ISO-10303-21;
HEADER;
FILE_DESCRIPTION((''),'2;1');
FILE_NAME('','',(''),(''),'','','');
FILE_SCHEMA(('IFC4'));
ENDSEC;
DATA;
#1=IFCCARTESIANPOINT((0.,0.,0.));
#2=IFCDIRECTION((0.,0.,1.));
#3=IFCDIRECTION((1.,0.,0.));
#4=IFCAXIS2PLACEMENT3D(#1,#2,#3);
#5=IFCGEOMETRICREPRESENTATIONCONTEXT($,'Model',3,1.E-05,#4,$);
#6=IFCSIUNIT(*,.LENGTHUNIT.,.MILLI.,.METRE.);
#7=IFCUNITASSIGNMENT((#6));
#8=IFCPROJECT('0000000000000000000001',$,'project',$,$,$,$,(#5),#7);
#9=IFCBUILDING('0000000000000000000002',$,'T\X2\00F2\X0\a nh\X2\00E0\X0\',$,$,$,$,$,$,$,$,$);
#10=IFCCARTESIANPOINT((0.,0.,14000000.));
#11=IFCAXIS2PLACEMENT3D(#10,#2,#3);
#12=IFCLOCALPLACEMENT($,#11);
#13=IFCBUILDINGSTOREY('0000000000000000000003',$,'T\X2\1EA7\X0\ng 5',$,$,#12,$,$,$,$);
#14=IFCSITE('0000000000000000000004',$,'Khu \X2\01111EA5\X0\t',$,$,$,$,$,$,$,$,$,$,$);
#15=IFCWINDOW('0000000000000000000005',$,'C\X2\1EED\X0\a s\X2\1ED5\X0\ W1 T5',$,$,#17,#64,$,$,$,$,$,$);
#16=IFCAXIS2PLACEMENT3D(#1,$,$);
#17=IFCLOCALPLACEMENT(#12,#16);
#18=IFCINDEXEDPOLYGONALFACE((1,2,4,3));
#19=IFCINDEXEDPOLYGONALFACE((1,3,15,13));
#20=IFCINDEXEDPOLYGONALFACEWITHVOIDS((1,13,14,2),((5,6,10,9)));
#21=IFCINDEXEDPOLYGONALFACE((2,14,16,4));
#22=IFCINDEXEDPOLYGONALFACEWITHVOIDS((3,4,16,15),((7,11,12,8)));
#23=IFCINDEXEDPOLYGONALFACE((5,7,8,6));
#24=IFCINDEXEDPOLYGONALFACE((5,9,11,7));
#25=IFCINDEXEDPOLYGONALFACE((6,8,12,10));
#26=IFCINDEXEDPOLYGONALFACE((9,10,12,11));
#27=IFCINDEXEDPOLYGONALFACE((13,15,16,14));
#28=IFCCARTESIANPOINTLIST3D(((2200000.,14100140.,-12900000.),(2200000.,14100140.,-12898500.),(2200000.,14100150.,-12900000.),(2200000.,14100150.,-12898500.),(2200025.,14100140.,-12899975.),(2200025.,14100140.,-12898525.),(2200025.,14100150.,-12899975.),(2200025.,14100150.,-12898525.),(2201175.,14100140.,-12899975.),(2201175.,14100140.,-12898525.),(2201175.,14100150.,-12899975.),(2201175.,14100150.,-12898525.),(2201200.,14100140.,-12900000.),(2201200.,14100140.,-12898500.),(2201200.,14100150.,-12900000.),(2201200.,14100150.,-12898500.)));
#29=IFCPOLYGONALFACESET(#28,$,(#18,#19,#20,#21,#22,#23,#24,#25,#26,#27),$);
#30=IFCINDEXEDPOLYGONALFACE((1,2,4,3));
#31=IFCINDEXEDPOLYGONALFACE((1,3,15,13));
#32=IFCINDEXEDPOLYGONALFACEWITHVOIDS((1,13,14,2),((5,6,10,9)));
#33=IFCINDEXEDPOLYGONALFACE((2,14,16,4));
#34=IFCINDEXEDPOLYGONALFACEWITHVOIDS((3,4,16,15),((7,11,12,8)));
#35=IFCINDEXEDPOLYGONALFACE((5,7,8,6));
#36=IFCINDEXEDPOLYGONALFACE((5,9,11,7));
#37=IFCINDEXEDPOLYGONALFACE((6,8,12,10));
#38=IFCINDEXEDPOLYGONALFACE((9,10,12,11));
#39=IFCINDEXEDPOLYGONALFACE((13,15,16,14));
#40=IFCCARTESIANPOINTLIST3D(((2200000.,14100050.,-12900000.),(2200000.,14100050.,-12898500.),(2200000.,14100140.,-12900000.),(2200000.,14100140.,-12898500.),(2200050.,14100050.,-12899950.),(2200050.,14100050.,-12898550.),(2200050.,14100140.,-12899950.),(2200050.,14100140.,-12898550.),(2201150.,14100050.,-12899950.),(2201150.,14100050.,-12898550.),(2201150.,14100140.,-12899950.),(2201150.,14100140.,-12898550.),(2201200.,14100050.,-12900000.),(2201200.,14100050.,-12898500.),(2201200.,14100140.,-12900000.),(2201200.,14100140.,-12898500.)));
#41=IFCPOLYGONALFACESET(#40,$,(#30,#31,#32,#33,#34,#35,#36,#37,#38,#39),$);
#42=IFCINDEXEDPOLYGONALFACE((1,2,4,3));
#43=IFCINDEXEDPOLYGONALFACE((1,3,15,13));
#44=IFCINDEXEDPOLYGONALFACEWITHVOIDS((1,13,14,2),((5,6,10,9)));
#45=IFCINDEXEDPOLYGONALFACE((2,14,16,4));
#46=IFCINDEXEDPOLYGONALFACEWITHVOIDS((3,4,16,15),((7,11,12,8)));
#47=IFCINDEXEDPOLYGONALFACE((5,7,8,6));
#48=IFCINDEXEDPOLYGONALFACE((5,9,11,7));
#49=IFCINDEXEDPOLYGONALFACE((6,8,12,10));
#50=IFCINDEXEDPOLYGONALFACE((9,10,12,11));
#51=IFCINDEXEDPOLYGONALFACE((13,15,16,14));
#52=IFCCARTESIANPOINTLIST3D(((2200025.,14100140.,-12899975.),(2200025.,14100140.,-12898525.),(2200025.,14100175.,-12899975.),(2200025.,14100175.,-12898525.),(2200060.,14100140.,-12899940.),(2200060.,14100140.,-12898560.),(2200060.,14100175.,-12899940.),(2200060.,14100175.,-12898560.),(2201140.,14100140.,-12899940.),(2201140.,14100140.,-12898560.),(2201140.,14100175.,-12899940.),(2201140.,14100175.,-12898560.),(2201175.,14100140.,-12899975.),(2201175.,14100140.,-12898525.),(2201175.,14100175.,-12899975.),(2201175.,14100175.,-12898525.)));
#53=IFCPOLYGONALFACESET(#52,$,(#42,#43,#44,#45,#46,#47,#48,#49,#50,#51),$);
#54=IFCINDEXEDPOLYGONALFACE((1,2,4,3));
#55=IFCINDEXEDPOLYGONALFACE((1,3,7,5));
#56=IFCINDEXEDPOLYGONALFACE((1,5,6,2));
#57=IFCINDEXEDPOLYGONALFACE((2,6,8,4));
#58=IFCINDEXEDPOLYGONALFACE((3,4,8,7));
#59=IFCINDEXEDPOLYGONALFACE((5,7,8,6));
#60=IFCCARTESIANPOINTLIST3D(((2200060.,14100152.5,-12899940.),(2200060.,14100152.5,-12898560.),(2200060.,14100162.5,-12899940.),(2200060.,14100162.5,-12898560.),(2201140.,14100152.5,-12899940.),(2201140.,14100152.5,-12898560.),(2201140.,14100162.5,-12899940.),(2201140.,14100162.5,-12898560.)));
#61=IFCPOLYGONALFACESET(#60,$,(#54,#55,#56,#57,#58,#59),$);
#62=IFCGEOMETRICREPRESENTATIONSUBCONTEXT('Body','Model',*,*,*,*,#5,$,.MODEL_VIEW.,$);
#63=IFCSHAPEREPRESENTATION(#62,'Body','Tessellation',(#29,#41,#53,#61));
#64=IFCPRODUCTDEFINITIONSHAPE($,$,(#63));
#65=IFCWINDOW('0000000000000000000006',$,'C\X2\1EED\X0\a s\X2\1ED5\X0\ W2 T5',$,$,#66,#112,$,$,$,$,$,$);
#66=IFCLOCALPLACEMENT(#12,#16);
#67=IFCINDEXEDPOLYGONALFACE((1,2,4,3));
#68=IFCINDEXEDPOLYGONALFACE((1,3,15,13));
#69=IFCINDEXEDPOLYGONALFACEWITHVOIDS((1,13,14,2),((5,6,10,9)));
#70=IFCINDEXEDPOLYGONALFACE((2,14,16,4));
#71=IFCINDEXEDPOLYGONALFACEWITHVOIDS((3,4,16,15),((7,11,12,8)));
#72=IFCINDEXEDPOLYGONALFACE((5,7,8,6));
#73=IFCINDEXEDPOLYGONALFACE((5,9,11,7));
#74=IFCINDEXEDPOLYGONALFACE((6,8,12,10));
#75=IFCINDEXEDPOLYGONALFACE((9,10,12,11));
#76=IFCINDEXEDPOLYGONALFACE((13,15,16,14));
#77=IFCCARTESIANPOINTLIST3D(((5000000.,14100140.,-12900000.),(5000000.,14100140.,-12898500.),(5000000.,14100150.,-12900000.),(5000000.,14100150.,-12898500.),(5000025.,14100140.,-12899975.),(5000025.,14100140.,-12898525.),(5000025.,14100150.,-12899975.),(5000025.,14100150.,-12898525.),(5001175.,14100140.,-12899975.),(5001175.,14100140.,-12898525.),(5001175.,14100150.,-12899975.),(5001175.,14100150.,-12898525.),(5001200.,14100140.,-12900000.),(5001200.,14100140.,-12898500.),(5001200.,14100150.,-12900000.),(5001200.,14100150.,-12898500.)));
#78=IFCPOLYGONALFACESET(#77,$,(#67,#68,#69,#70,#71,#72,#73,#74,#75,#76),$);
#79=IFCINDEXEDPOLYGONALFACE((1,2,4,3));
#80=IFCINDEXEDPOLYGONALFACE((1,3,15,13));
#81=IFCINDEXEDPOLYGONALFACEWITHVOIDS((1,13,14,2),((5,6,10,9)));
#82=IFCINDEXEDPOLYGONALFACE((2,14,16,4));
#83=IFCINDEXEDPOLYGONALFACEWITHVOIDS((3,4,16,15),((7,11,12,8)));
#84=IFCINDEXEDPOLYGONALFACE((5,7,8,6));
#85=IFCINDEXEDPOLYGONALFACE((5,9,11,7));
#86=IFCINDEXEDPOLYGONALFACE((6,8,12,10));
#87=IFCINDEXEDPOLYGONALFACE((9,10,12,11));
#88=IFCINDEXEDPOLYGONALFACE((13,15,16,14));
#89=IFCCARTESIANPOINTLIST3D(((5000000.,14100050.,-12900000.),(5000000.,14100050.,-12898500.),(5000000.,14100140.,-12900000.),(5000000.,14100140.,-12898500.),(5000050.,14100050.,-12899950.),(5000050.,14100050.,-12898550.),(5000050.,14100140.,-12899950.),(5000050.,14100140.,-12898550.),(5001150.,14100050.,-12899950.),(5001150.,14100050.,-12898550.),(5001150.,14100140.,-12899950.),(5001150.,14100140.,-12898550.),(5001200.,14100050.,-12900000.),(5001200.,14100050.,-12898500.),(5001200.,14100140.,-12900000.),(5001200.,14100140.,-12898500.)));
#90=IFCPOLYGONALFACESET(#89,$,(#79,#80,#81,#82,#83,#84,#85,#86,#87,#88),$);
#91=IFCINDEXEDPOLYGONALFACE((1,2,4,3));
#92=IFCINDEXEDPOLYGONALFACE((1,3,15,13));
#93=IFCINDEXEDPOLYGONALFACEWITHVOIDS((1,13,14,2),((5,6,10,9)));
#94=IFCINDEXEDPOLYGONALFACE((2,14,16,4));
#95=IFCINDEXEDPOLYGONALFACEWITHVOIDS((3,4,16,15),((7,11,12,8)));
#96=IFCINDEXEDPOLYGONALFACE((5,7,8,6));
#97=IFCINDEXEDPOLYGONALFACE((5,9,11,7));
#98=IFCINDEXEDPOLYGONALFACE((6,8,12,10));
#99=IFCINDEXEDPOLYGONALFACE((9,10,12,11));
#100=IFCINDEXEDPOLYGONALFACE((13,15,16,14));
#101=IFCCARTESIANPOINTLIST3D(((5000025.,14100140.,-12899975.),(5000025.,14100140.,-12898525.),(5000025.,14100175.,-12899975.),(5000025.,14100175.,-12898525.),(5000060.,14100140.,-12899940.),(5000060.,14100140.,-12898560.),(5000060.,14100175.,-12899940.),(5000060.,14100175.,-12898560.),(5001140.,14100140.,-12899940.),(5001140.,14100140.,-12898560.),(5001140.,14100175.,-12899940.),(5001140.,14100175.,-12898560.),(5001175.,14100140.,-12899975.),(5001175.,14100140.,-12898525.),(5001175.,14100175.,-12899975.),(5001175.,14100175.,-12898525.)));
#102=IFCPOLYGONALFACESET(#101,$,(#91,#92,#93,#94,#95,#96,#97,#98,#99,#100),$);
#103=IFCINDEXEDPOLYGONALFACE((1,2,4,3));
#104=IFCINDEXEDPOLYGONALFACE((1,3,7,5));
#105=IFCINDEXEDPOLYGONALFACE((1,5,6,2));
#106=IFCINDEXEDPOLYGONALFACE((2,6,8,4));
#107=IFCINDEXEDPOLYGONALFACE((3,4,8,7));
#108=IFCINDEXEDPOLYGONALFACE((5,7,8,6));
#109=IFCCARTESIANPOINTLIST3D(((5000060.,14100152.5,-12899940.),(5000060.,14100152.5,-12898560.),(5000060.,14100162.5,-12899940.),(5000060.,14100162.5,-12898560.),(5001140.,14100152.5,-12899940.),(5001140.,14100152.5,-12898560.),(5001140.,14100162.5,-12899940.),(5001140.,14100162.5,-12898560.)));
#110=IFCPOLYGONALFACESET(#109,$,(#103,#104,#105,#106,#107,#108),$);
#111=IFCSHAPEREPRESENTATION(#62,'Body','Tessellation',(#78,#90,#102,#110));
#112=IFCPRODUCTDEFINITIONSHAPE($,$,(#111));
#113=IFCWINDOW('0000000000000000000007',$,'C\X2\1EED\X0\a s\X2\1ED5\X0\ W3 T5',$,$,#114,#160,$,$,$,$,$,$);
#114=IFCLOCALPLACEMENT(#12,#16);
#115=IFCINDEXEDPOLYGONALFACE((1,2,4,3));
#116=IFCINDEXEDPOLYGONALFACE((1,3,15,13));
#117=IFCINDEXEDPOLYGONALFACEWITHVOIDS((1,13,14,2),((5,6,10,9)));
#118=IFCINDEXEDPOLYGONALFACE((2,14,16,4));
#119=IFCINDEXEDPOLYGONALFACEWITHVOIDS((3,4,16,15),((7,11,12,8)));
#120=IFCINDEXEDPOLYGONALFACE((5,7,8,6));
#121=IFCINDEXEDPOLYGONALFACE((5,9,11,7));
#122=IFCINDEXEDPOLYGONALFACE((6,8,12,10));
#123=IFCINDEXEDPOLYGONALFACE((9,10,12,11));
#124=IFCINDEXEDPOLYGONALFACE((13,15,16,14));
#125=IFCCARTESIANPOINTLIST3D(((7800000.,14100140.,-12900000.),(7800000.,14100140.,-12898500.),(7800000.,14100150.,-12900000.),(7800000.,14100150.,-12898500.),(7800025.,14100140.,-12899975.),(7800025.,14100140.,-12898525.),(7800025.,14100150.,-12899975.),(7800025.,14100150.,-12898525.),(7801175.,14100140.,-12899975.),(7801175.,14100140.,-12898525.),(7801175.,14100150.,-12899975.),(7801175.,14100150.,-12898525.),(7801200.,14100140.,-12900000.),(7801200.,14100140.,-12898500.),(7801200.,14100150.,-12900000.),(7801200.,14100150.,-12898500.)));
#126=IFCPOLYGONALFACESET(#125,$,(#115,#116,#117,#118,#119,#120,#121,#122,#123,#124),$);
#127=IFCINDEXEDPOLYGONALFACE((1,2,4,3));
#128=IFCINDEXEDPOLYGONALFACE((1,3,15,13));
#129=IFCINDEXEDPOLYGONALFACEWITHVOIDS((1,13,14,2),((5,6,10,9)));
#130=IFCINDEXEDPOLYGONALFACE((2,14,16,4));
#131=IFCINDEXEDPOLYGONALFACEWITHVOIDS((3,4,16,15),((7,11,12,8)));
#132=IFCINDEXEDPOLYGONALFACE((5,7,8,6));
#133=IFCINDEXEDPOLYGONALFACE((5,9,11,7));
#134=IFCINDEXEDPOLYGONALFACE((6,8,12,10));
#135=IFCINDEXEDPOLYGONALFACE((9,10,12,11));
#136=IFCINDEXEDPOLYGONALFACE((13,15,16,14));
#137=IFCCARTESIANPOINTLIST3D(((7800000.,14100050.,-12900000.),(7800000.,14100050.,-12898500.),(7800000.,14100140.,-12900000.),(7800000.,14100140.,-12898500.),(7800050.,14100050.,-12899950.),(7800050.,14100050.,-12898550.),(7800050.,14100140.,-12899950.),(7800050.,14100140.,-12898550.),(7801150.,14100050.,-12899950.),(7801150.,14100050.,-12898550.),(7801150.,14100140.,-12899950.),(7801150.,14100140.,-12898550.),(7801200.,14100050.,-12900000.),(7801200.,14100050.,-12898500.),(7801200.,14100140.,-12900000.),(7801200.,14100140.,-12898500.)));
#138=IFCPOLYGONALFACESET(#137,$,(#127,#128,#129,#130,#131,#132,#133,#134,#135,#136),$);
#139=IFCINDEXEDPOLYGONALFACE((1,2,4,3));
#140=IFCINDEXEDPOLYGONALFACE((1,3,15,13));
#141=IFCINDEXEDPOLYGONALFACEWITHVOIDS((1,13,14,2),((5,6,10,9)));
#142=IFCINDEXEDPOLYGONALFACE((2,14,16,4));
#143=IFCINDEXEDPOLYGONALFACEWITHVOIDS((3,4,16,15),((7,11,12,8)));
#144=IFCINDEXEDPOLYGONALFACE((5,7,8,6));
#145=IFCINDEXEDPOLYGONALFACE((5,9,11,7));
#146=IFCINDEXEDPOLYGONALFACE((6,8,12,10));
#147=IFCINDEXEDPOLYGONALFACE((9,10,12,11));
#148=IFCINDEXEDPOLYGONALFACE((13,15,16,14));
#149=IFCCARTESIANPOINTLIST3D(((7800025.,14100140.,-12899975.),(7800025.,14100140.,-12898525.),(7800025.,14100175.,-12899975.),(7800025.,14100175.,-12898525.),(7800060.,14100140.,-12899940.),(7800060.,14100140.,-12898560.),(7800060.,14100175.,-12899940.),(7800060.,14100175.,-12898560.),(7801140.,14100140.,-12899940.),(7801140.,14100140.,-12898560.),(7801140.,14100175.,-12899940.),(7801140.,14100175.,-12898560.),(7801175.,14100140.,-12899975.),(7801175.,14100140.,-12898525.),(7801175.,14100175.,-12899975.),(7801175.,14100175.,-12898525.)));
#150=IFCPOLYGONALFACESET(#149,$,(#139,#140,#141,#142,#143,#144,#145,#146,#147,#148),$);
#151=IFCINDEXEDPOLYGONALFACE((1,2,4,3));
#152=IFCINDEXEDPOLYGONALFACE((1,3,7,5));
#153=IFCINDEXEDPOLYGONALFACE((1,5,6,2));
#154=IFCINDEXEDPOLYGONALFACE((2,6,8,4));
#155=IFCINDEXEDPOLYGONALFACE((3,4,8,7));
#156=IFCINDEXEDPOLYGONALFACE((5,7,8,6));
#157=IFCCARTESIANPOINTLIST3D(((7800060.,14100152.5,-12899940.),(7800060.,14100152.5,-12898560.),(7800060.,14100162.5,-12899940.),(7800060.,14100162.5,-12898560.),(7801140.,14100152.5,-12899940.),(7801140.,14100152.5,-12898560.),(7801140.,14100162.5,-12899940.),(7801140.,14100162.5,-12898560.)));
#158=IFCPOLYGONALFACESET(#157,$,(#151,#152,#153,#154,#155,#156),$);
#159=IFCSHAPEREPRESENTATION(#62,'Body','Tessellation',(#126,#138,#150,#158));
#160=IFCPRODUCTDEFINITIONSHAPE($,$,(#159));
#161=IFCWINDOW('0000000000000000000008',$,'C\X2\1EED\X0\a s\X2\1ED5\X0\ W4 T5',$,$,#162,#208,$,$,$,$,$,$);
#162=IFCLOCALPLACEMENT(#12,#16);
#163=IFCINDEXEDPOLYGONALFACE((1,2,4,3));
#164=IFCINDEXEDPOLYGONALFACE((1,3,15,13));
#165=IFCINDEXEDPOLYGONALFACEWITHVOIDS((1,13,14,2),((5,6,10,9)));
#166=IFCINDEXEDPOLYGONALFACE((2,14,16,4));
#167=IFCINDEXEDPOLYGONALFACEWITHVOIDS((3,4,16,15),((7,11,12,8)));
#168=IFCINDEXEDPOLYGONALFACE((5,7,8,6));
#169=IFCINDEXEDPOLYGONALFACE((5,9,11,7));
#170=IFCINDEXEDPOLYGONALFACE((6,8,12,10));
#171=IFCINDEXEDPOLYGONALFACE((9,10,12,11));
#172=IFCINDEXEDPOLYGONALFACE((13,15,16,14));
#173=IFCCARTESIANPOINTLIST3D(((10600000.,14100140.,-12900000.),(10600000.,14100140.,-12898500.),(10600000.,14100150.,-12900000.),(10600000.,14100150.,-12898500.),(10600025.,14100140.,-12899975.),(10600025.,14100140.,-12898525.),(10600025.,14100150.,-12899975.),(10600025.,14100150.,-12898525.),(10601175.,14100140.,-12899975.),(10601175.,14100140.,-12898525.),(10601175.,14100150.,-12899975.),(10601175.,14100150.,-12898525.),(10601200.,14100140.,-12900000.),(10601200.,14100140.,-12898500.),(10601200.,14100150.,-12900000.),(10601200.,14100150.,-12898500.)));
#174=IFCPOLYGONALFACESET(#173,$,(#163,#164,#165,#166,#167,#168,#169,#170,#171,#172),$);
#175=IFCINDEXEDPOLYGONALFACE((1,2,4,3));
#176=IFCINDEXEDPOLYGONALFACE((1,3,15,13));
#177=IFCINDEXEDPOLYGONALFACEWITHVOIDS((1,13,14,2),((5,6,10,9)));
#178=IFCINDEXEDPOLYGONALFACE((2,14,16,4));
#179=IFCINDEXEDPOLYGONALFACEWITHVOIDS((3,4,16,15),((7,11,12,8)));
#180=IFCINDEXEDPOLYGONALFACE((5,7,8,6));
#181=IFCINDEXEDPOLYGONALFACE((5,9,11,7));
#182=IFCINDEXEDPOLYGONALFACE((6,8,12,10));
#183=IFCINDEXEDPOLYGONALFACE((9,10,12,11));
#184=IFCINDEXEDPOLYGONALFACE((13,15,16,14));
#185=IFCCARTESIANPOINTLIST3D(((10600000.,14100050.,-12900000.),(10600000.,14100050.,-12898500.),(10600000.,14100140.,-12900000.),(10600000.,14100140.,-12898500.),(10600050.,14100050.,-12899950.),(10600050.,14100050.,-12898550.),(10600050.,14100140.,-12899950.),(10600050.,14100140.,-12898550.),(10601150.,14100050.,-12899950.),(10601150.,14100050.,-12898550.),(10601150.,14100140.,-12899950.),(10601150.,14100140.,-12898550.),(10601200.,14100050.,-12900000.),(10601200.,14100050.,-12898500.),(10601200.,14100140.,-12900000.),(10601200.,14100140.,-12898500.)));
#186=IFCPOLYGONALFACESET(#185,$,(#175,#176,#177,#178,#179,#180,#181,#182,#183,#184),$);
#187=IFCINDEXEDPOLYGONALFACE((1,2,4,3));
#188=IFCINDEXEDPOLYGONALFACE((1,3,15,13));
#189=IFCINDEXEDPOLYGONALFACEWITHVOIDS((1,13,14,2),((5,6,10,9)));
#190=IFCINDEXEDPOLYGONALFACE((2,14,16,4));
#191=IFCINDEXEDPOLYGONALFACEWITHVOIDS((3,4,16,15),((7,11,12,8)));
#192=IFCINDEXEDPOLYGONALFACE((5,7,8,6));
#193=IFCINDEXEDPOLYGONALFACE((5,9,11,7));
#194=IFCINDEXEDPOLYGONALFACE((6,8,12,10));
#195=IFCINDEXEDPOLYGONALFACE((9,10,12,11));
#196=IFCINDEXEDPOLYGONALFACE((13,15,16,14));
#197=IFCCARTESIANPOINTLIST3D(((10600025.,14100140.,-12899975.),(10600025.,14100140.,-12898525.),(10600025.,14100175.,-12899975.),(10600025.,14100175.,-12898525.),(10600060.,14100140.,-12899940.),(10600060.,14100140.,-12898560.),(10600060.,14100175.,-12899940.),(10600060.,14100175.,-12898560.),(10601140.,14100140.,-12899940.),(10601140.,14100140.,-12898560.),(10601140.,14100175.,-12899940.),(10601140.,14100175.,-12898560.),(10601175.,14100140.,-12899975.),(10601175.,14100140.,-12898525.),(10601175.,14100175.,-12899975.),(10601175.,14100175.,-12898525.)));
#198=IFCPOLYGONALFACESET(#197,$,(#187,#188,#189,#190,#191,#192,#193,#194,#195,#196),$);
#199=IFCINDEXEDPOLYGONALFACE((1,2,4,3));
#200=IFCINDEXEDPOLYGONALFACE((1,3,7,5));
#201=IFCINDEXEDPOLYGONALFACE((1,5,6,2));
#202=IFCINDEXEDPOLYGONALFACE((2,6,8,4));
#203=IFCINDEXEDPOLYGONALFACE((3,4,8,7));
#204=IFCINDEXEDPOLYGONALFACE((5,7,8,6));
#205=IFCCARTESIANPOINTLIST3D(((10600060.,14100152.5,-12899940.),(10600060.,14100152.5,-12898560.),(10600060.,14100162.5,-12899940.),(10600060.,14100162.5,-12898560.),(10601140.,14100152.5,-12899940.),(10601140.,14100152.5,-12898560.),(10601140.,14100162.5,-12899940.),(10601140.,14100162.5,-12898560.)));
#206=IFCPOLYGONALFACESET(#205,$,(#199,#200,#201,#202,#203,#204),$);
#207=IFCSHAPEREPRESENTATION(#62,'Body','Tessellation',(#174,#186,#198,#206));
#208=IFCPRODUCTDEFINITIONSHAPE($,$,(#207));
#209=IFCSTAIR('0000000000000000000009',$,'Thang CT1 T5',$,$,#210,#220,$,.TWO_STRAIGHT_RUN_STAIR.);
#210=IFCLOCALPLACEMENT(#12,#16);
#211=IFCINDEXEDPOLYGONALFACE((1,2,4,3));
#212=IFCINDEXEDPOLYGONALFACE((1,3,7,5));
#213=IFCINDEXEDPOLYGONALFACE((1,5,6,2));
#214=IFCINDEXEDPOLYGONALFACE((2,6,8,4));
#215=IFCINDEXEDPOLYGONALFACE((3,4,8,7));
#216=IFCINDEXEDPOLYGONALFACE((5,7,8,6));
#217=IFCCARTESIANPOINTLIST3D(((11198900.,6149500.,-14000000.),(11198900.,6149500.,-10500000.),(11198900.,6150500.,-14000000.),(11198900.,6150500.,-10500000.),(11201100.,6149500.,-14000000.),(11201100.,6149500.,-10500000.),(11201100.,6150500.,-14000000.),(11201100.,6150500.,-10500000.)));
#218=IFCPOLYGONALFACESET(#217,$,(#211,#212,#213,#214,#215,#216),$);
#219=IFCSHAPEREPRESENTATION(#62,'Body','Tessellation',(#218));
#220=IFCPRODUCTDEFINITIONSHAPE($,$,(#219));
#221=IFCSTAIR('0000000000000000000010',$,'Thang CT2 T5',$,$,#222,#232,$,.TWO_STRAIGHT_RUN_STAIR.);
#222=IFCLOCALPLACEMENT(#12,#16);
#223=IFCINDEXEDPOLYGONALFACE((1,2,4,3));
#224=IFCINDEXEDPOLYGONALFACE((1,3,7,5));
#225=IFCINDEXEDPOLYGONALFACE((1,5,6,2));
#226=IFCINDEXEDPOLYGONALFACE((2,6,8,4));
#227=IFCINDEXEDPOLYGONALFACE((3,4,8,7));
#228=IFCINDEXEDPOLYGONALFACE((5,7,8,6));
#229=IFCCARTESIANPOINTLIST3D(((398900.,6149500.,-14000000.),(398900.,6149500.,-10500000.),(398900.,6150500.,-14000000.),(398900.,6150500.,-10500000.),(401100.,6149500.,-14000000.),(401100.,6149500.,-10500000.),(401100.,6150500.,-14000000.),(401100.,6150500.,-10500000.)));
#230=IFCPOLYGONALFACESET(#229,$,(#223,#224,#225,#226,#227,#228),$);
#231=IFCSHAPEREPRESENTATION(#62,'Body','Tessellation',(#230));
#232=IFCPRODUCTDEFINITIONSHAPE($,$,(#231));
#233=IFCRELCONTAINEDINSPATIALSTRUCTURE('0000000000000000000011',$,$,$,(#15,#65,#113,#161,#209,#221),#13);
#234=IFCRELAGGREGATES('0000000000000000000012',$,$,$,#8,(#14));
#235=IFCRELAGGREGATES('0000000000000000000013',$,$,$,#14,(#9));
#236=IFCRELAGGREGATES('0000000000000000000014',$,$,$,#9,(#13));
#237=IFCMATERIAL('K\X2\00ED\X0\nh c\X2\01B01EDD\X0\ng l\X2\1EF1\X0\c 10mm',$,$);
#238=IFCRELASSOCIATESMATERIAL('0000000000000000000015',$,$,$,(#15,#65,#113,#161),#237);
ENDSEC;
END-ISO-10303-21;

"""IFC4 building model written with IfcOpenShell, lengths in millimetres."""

from ifc_helpers import new_model, entity, si_unit, frame, origin_with_axes, place, context, subcontext, project, spatial, line, indexed_curve, outline, extrude, material, element, save


model = new_model("IFC4")

# Units and contexts
model_context = context("Model", 3, precision=1e-05, world=origin_with_axes())
body_context = subcontext(model_context, "Body", "Model", "MODEL_VIEW")
ifc_project = project(units=[si_unit("LENGTHUNIT", "METRE", prefix="MILLI")], contexts=[model_context])

# Site, building, storey
site = spatial("IfcSite", under=ifc_project, Name="Khu đất")
building = spatial("IfcBuilding", under=site, Name="Tòa nhà")
storey_placement = place(None, frame((0.0, 0.0, 14000000.0), z_axis=(0.0, 0.0, 1.0), x_axis=(1.0, 0.0, 0.0)))
storey = spatial("IfcBuildingStorey", under=building, at=storey_placement, Name="Tầng 5")

# Windows
ifc_material_1 = material(Name="Kính cường lực 10mm")
for number, where, z_axis, x_axis, name in (
    (1, (2200000.0, 14100000.0, -12900000.0), (0.0, 0.0, 1.0), (1.0, 0.0, 0.0), "Cửa sổ W1 T5"),
    (2, (5000000.0, 14100000.0, -12900000.0), (0.0, 0.0, 1.0), (1.0, 0.0, 0.0), "Cửa sổ W2 T5"),
    (3, (7800000.0, 14100000.0, -12900000.0), (0.0, 0.0, 1.0), (1.0, 0.0, 0.0), "Cửa sổ W3 T5"),
    (4, (10600000.0, 14100000.0, -12900000.0), (0.0, 0.0, 1.0), (1.0, 0.0, 0.0), "Cửa sổ W4 T5"),
):
    element("IfcWindow", number, at=place(storey_placement, frame(where, z_axis=z_axis, x_axis=x_axis)), inside=storey, material=ifc_material_1, Name=name, context=body_context, shape_type="SolidModel", body=[
        extrude(outline(indexed_curve([(0.0, 0.0), (1200.0, 0.0), (1200.0, 1500.0), (0.0, 1500.0)], segments=[line(1, 2, 3, 4, 1)]), holes=[indexed_curve([(25.0, 25.0), (1175.0, 25.0), (1175.0, 1475.0), (25.0, 1475.0)], segments=[line(1, 2, 3, 4, 1)])]), frame((0.0, 140.0, 0.0), z_axis=(0.0, -1.0, 0.0), x_axis=(1.0, 0.0, 0.0)), (0.0, 0.0, -1.0), 10.0),
        extrude(outline(indexed_curve([(0.0, 0.0), (1200.0, 0.0), (1200.0, 1500.0), (0.0, 1500.0)], segments=[line(1, 2, 3, 4, 1)]), holes=[indexed_curve([(50.0, 50.0), (1150.0, 50.0), (1150.0, 1450.0), (50.0, 1450.0)], segments=[line(1, 2, 3, 4, 1)])]), frame((0.0, 50.0, 0.0), z_axis=(0.0, -1.0, 0.0), x_axis=(1.0, 0.0, 0.0)), (0.0, 0.0, -1.0), 90.0),
        extrude(outline(indexed_curve([(0.0, 0.0), (1150.0, 0.0), (1150.0, 1450.0), (0.0, 1450.0)], segments=[line(1, 2, 3, 4, 1)]), holes=[indexed_curve([(35.0, 35.0), (1115.0, 35.0), (1115.0, 1415.0), (35.0, 1415.0)], segments=[line(1, 2, 3, 4, 1)])]), frame((25.0, 140.0, 25.0), z_axis=(0.0, -1.0, 0.0), x_axis=(1.0, 0.0, 0.0)), (0.0, 0.0, -1.0), 35.0),
        extrude(outline(indexed_curve([(35.0, 35.0), (1115.0, 35.0), (1115.0, 1415.0), (35.0, 1415.0)], segments=[line(1, 2, 3, 4, 1)])), frame((25.0, 152.5, 25.0), z_axis=(0.0, -1.0, 0.0), x_axis=(1.0, 0.0, 0.0)), (0.0, 0.0, -1.0), 10.0),
    ])

# Stairs
for number, where, z_axis, x_axis, name in (
    (5, (11200000.0, 6150000.0, -14000000.0), (0.0, 0.0, 1.0), (1.0, 0.0, 0.0), "Thang CT1 T5"),
    (6, (400000.0, 6150000.0, -14000000.0), (0.0, 0.0, 1.0), (1.0, 0.0, 0.0), "Thang CT2 T5"),
):
    element("IfcStair", number, at=place(storey_placement, frame(where, z_axis=z_axis, x_axis=x_axis)), inside=storey, Name=name, PredefinedType="TWO_STRAIGHT_RUN_STAIR", context=body_context, shape_type="SweptSolid", body=[
        extrude(entity("IfcRectangleProfileDef", None, None, None, 2200.0, 1000.0), origin_with_axes(), (0.0, 0.0, 1.0), 3500000.0),
    ])

save(model, "model.ifc")
